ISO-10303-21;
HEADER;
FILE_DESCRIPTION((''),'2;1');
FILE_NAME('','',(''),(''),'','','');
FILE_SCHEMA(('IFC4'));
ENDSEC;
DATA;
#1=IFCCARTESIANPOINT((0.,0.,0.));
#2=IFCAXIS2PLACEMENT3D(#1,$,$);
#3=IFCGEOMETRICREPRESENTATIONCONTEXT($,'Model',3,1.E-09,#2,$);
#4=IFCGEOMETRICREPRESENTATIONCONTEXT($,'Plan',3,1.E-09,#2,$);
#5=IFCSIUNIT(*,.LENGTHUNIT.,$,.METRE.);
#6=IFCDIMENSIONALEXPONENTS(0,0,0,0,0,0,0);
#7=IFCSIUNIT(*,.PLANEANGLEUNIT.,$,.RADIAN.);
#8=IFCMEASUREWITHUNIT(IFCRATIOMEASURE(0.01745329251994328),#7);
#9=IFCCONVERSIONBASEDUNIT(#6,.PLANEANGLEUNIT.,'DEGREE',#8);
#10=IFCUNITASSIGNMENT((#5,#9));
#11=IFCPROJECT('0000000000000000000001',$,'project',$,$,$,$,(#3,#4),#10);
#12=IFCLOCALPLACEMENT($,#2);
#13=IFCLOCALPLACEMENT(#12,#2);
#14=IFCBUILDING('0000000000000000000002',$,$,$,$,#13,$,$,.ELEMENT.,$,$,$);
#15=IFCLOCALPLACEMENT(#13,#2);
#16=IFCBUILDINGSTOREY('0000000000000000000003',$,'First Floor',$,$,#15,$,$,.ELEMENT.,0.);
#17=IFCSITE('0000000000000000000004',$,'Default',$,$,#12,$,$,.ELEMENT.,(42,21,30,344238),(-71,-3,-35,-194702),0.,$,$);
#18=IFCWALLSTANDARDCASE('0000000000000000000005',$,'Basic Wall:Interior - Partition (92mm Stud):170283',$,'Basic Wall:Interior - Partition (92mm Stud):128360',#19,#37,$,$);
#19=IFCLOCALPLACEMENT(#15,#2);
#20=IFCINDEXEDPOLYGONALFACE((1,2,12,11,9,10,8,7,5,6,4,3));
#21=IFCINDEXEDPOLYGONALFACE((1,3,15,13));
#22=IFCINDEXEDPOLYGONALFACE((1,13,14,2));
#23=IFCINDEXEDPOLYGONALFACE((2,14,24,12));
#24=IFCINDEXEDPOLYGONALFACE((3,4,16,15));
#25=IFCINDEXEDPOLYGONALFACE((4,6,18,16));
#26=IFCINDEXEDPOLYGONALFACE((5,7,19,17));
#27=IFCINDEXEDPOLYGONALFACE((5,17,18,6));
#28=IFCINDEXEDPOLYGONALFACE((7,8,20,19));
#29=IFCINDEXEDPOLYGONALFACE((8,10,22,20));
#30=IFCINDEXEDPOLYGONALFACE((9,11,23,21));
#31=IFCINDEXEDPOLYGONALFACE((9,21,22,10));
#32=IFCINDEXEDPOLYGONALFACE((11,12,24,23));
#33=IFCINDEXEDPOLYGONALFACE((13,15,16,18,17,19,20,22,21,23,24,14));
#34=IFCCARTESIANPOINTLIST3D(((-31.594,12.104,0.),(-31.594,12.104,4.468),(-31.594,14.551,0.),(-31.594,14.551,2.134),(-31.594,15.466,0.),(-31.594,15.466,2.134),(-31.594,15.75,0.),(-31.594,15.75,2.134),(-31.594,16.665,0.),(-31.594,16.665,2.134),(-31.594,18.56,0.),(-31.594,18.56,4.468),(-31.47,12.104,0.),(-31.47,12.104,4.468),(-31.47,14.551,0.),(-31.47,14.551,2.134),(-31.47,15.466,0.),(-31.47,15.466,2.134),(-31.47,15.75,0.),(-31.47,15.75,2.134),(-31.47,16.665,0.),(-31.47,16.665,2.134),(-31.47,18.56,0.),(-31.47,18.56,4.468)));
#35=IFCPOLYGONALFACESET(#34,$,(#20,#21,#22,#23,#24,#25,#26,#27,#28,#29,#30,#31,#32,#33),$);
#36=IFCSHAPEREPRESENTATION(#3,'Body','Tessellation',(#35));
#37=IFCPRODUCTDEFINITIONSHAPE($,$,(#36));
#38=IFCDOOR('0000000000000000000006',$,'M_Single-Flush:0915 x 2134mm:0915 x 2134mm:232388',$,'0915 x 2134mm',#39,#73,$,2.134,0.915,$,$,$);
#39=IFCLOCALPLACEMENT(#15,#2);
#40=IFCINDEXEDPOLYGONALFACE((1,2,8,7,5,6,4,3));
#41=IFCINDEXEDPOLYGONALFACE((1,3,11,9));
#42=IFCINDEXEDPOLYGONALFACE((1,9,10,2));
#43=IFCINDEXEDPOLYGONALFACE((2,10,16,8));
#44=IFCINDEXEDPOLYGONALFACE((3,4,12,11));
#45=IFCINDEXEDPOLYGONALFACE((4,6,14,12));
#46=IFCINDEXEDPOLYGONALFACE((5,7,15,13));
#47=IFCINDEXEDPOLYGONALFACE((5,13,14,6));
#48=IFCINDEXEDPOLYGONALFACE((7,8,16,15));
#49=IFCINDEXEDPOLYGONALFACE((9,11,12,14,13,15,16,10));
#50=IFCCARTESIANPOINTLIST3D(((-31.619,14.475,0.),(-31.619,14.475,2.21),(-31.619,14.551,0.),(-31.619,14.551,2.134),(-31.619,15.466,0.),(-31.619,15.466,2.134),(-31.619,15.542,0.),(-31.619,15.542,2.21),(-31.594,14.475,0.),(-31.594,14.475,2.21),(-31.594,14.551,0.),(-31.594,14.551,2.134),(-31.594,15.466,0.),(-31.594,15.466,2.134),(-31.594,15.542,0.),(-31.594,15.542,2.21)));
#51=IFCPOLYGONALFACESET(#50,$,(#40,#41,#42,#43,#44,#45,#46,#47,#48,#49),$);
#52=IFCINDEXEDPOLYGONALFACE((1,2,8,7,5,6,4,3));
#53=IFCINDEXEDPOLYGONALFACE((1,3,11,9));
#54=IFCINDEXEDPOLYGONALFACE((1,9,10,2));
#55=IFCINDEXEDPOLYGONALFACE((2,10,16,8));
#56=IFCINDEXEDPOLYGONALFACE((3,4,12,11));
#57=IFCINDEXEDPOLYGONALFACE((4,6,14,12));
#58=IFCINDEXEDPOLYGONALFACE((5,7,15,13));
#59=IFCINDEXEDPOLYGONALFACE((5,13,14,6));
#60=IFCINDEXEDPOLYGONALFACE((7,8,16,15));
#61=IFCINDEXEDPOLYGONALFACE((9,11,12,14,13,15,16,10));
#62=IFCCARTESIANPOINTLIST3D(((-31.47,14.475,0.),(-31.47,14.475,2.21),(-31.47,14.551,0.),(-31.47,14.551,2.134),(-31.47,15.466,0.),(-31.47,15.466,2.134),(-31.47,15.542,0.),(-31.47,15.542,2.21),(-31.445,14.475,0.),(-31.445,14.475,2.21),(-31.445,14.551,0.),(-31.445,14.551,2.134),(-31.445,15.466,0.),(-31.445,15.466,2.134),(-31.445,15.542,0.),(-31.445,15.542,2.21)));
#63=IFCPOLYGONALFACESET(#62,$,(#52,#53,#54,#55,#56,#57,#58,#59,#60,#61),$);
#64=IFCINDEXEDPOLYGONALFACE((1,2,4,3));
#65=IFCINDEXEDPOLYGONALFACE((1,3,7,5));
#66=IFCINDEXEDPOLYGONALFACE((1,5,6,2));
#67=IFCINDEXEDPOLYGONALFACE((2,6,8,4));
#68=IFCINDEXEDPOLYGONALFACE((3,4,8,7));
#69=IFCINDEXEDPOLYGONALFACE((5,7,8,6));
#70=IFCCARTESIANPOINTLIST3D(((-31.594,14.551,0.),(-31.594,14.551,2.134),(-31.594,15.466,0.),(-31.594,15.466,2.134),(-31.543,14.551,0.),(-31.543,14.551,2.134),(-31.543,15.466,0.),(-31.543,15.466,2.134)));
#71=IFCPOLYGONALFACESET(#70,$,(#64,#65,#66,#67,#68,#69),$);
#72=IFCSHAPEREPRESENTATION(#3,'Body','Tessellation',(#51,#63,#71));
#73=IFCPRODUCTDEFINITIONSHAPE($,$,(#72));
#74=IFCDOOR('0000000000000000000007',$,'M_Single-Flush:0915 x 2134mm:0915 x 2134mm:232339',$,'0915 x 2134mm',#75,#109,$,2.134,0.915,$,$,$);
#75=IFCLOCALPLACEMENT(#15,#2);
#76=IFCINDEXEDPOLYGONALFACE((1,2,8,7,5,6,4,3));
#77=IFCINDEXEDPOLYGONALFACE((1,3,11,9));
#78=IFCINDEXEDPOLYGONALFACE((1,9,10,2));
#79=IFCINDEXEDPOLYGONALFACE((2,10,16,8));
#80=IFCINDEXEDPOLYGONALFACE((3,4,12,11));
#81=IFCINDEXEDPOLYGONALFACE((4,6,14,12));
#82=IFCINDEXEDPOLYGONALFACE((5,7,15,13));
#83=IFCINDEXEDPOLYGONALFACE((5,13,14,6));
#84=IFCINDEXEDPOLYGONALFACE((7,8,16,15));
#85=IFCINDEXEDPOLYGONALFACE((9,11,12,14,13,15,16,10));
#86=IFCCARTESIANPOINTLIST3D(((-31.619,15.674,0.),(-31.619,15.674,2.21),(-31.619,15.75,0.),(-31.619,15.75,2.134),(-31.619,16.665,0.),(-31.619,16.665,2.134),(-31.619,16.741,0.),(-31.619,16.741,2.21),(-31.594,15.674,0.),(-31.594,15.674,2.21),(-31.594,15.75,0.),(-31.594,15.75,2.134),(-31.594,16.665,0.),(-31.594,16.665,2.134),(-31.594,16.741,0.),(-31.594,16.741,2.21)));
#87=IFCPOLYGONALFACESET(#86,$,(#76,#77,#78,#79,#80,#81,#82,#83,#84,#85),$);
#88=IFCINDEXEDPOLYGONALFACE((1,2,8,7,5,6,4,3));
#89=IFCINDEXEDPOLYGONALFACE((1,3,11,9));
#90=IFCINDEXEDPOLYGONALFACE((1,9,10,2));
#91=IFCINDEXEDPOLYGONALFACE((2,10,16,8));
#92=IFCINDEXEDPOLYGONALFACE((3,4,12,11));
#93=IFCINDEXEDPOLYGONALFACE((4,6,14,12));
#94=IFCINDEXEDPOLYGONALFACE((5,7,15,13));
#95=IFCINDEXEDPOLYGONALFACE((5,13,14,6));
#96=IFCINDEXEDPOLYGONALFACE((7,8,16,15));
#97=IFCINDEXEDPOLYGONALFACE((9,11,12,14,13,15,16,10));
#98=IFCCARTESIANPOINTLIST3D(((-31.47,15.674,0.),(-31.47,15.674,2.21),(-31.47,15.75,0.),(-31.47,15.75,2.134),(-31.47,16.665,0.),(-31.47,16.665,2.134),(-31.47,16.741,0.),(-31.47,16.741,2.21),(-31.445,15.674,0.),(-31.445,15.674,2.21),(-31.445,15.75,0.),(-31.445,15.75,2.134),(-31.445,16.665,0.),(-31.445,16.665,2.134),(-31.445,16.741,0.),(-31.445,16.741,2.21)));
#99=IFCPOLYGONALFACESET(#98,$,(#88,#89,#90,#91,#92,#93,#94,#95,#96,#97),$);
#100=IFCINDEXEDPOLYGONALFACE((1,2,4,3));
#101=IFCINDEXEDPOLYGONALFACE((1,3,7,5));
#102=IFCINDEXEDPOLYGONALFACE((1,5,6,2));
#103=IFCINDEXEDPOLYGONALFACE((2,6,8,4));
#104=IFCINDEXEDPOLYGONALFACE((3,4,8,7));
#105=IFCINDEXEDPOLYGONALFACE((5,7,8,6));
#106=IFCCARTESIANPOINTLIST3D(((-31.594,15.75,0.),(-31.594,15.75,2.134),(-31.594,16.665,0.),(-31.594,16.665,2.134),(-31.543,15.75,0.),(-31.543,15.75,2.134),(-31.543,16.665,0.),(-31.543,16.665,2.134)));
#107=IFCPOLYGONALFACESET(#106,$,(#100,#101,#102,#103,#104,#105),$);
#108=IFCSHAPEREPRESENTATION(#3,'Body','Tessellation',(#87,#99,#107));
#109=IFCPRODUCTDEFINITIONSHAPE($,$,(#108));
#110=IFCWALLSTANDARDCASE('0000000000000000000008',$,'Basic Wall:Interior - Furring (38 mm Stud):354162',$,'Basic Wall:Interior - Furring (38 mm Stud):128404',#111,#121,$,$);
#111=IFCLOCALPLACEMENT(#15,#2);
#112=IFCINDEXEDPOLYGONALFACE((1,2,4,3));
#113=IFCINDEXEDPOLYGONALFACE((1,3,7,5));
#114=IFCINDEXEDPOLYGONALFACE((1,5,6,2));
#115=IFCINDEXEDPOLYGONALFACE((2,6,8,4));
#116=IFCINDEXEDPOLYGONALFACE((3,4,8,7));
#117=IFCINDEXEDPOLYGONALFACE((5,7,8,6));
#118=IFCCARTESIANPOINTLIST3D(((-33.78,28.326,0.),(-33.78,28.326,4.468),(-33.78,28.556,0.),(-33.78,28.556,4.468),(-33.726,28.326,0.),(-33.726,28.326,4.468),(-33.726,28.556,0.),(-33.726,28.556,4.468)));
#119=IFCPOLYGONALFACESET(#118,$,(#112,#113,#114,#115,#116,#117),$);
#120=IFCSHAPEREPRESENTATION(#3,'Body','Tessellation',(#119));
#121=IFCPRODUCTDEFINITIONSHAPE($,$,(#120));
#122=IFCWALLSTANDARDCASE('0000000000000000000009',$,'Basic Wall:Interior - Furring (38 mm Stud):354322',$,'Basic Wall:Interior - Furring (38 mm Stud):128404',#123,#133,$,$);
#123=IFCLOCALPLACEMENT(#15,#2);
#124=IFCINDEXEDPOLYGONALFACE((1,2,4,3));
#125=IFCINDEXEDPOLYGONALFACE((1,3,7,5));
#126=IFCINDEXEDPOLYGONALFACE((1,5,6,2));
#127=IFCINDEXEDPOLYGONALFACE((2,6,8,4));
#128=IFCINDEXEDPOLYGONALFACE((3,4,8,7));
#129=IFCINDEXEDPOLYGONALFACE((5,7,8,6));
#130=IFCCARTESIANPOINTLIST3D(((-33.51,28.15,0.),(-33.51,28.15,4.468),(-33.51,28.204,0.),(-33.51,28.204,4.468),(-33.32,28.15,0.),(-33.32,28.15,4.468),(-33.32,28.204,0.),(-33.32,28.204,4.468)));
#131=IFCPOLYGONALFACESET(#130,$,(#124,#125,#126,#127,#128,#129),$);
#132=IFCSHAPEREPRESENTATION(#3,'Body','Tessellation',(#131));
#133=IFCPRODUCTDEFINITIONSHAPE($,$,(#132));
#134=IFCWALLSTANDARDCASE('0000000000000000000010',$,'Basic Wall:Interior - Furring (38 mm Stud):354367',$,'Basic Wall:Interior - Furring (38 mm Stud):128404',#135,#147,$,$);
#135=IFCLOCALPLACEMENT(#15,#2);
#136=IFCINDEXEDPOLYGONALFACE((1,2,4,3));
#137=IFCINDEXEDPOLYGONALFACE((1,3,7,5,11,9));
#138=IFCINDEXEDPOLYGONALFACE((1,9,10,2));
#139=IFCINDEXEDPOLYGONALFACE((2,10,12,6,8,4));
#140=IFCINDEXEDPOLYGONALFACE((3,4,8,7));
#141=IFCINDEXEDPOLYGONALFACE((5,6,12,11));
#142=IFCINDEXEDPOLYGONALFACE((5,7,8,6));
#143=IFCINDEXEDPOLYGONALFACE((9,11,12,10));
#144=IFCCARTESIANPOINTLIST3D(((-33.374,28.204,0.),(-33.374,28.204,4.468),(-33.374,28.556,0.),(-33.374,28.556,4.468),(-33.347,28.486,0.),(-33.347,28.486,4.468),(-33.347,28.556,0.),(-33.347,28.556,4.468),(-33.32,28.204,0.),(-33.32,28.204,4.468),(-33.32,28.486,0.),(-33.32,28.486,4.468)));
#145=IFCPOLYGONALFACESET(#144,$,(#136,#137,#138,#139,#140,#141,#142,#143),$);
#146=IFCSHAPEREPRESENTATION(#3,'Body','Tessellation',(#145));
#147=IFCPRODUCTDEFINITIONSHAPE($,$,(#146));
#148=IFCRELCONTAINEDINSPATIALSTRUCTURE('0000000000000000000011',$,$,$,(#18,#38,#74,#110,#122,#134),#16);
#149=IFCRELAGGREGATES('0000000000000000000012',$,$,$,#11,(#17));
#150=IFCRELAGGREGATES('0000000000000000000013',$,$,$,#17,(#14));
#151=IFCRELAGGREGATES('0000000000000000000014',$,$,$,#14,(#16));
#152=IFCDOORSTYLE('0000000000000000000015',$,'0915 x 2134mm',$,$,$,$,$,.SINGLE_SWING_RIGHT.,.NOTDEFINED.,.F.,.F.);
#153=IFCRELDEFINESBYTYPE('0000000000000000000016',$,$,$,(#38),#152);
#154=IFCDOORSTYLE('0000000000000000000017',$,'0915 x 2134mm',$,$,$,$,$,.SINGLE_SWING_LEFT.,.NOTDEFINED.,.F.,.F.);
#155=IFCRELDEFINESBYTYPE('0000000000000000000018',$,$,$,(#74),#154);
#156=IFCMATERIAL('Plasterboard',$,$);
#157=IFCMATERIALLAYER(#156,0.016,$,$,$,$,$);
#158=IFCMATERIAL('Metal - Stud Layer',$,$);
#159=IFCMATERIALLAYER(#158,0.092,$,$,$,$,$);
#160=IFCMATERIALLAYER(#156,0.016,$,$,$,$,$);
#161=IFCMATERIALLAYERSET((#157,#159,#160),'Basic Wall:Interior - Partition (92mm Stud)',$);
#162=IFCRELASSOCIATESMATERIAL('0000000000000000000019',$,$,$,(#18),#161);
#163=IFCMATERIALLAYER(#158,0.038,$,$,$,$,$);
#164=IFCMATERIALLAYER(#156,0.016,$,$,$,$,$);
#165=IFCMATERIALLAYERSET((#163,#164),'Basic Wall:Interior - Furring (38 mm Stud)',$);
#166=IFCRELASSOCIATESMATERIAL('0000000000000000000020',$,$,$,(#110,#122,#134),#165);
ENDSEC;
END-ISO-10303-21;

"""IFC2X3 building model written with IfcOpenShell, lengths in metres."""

from ifc_helpers import new_model, entity, si_unit, converted_unit, frame, frame_2d, origin, origin_2d_with_axis, place, context, project, spatial, polyline, rectangle, outline, extrude, source, transform, mapped, material, layer, layer_set, layer_usage, type_object, type_shapes, element, fill, save


model = new_model("IFC2X3")

# Units and contexts
model_context = context("Model", 3, precision=1e-09, world=origin())
plan_context = context("Plan", 3, precision=1e-09, world=origin())
ifc_project = project(units=[si_unit("LENGTHUNIT", "METRE"), converted_unit("PLANEANGLEUNIT", "DEGREE", entity("IfcRatioMeasure", 0.01745329251994328), si_unit("PLANEANGLEUNIT", "RADIAN"), dimensions=[0, 0, 0, 0, 0, 0, 0])], contexts=[model_context, plan_context])

# Site, building, storey
site_placement = place(None, origin())
site = spatial("IfcSite", under=ifc_project, at=site_placement, Name="Default", CompositionType="ELEMENT", RefLatitude=(42, 21, 30, 344238), RefLongitude=(-71, -3, -35, -194702), RefElevation=0.0)
building_placement = place(site_placement, origin())
building = spatial("IfcBuilding", under=site, at=building_placement, CompositionType="ELEMENT")
storey_placement = place(building_placement, origin())
storey = spatial("IfcBuildingStorey", under=building, at=storey_placement, Name="First Floor", CompositionType="ELEMENT", Elevation=0.0)

# Shared definitions
ifc_material_1 = material(Name="Plasterboard")
ifc_layer_1 = layer(ifc_material_1, 0.016)
ifc_material_2 = material(Name="Metal - Stud Layer")
ifc_layer_2 = layer(ifc_material_2, 0.092)
ifc_layer_3 = layer(ifc_material_1, 0.016)
ifc_layer_set_1 = layer_set([ifc_layer_1, ifc_layer_2, ifc_layer_3], Name="Basic Wall:Interior - Partition (92mm Stud)")

# Shared definitions
door_style_1 = type_object("IfcDoorStyle", Name="0915 x 2134mm", ConstructionType="NOTDEFINED", OperationType="SINGLE_SWING_RIGHT", ParameterTakesPrecedence=False, Sizeable=False)
shared_shape_1 = source(origin(), model_context, "Body", "SweptSolid", [
    extrude(outline(polyline([(-0.5335, -1.124), (0.5335, -1.124), (0.5335, 1.086), (0.4575, 1.086), (0.4575, -1.048), (-0.4575, -1.048), (-0.4575, 1.086), (-0.5335, 1.086), (-0.5335, -1.124)])), frame((0.4575, 0.124, 1.086), z_axis=(0.0, 1.0, 0.0), x_axis=(1.0, 0.0, 0.0)), (0.0, 0.0, 1.0), 0.025),
    extrude(outline(polyline([(-1.124, -0.5335), (1.086, -0.5335), (1.086, -0.4575), (-1.048, -0.4575), (-1.048, 0.4575), (1.086, 0.4575), (1.086, 0.5335), (-1.124, 0.5335), (-1.124, -0.5335)])), frame((0.4575, -0.025, 1.086), z_axis=(0.0, 1.0, 0.0), x_axis=(0.0, 0.0, -1.0)), (0.0, 0.0, 1.0), 0.025),
    extrude(rectangle(XDim=0.051, YDim=0.915, at=origin_2d_with_axis()), frame((0.4575, 0.0985, 0.0), z_axis=(0.0, 0.0, 1.0), x_axis=(0.0, 1.0, 0.0)), (0.0, 0.0, 1.0), 2.134),
])
type_shapes(door_style_1, [shared_shape_1])

# Shared definitions
ifc_layer_4 = layer(ifc_material_2, 0.038)
ifc_layer_5 = layer(ifc_material_1, 0.016)
ifc_layer_set_2 = layer_set([ifc_layer_4, ifc_layer_5], Name="Basic Wall:Interior - Furring (38 mm Stud)")

# Wall, openings, doors
ifc_layer_usage_1 = layer_usage(ifc_layer_set_1, "AXIS2", "NEGATIVE", 0.062)
wall_1_placement = place(storey_placement, frame((-31.532, 18.56, 0.0), z_axis=(0.0, 0.0, 1.0), x_axis=(0.0, -1.0, 0.0)))
wall_1 = element("IfcWallStandardCase", 1, at=wall_1_placement, inside=storey, material=ifc_layer_usage_1, Name="Basic Wall:Interior - Partition (92mm Stud):170283", ObjectType="Basic Wall:Interior - Partition (92mm Stud):128360", context=model_context, shape_type="SweptSolid", body=[
    extrude(rectangle(XDim=6.456, YDim=0.124, at=frame_2d((3.228, 0.0), x_axis=(-1.0, 0.0))), origin(), (0.0, 0.0, 1.0), 4.468),
])
opening_1_placement = place(wall_1_placement, frame((2.81, 0.062, 0.0)))
opening_1 = element("IfcOpeningElement", 2, at=opening_1_placement, cuts=wall_1, ObjectType="Opening", context=model_context, shape_type="SweptSolid", body=[
    extrude(rectangle(XDim=0.915, YDim=2.134, at=frame_2d((1.067, 0.4575), x_axis=(0.0, -1.0))), frame((0.0, 0.0, 0.0), z_axis=(0.0, -1.0, 0.0), x_axis=(0.0, 0.0, 1.0)), (0.0, 0.0, 1.0), 0.124),
])
opening_2_placement = place(wall_1_placement, frame((4.009, 0.062, 0.0)))
opening_2 = element("IfcOpeningElement", 3, at=opening_2_placement, cuts=wall_1, ObjectType="Opening", context=model_context, shape_type="SweptSolid", body=[
    extrude(rectangle(XDim=0.915, YDim=2.134, at=frame_2d((1.067, 0.4575), x_axis=(0.0, 1.0))), frame((0.0, 0.0, 0.0), z_axis=(0.0, -1.0, 0.0), x_axis=(0.0, 0.0, 1.0)), (0.0, 0.0, 1.0), 0.124),
])
door_1_placement = place(opening_2_placement, frame((0.0, 0.0, 0.0), z_axis=(0.0, 0.0, 1.0), x_axis=(-1.0, 0.0, 0.0)))
door_1 = element("IfcDoor", 4, at=door_1_placement, inside=storey, type_object=door_style_1, Name="M_Single-Flush:0915 x 2134mm:0915 x 2134mm:232388", ObjectType="0915 x 2134mm", OverallHeight=2.134, OverallWidth=0.915, context=model_context, shape_type="MappedRepresentation", body=[
    mapped(shared_shape_1, transform((0.0, 0.0, 0.0), scale=1.0)),
])
fill(opening_2, door_1)
door_style_2 = type_object("IfcDoorStyle", Name="0915 x 2134mm", ConstructionType="NOTDEFINED", OperationType="SINGLE_SWING_LEFT", ParameterTakesPrecedence=False, Sizeable=False)
shared_shape_2 = source(origin(), model_context, "Body", "SweptSolid", [
    extrude(outline(polyline([(-0.5335, -1.124), (0.5335, -1.124), (0.5335, 1.086), (0.4575, 1.086), (0.4575, -1.048), (-0.4575, -1.048), (-0.4575, 1.086), (-0.5335, 1.086), (-0.5335, -1.124)])), frame((0.4575, 0.149, 1.086), z_axis=(0.0, -1.0, 0.0), x_axis=(-1.0, 0.0, 0.0)), (0.0, 0.0, 1.0), 0.025),
    extrude(outline(polyline([(-1.124, -0.5335), (1.086, -0.5335), (1.086, -0.4575), (-1.048, -0.4575), (-1.048, 0.4575), (1.086, 0.4575), (1.086, 0.5335), (-1.124, 0.5335), (-1.124, -0.5335)])), frame((0.4575, 0.0, 1.086), z_axis=(0.0, -1.0, 0.0), x_axis=(0.0, 0.0, -1.0)), (0.0, 0.0, 1.0), 0.025),
    extrude(rectangle(XDim=0.915, YDim=0.051, at=origin_2d_with_axis()), frame((0.4575, 0.0985, 0.0)), (0.0, 0.0, 1.0), 2.134),
])
type_shapes(door_style_2, [shared_shape_2])
door_2_placement = place(opening_1_placement, frame((0.0, 0.0, 0.0), z_axis=(0.0, 0.0, 1.0), x_axis=(-1.0, 0.0, 0.0)))
door_2 = element("IfcDoor", 5, at=door_2_placement, inside=storey, type_object=door_style_2, Name="M_Single-Flush:0915 x 2134mm:0915 x 2134mm:232339", ObjectType="0915 x 2134mm", OverallHeight=2.134, OverallWidth=0.915, context=model_context, shape_type="MappedRepresentation", body=[
    mapped(shared_shape_2, transform((0.0, 0.0, 0.0), scale=1.0)),
])
fill(opening_1, door_2)

# Walls
ifc_layer_usage_2 = layer_usage(ifc_layer_set_2, "AXIS2", "NEGATIVE", 0.027)
wall_2_placement = place(storey_placement, frame((-33.753, 28.556, 0.0), z_axis=(0.0, 0.0, 1.0), x_axis=(0.0, -1.0, 0.0)))
element("IfcWallStandardCase", 6, at=wall_2_placement, inside=storey, material=ifc_layer_usage_2, Name="Basic Wall:Interior - Furring (38 mm Stud):354162", ObjectType="Basic Wall:Interior - Furring (38 mm Stud):128404", context=model_context, shape_type="SweptSolid", body=[
    extrude(rectangle(XDim=0.23, YDim=0.054, at=frame_2d((0.115, 0.0), x_axis=(-1.0, 0.0))), origin(), (0.0, 0.0, 1.0), 4.468),
])
ifc_layer_usage_3 = layer_usage(ifc_layer_set_2, "AXIS2", "NEGATIVE", 0.027)
wall_3_placement = place(storey_placement, frame((-33.51, 28.177, 0.0)))
element("IfcWallStandardCase", 7, at=wall_3_placement, inside=storey, material=ifc_layer_usage_3, Name="Basic Wall:Interior - Furring (38 mm Stud):354322", ObjectType="Basic Wall:Interior - Furring (38 mm Stud):128404", context=model_context, shape_type="SweptSolid", body=[
    extrude(rectangle(XDim=0.19, YDim=0.054, at=frame_2d((0.095, 0.0), x_axis=(-1.0, 0.0))), origin(), (0.0, 0.0, 1.0), 4.468),
])
ifc_layer_usage_4 = layer_usage(ifc_layer_set_2, "AXIS2", "NEGATIVE", 0.027)
wall_4_placement = place(storey_placement, frame((-33.347, 28.204, 0.0), z_axis=(0.0, 0.0, 1.0), x_axis=(0.0, 1.0, 0.0)))
element("IfcWallStandardCase", 8, at=wall_4_placement, inside=storey, material=ifc_layer_usage_4, Name="Basic Wall:Interior - Furring (38 mm Stud):354367", ObjectType="Basic Wall:Interior - Furring (38 mm Stud):128404", context=model_context, shape_type="SweptSolid", body=[
    extrude(outline(polyline([(0.282, -0.027), (0.282, 0.0), (0.352, 0.0), (0.352, 0.027), (0.0, 0.027), (0.0, -0.027), (0.282, -0.027)])), origin(), (0.0, 0.0, 1.0), 4.468),
])

save(model, "model.ifc")
